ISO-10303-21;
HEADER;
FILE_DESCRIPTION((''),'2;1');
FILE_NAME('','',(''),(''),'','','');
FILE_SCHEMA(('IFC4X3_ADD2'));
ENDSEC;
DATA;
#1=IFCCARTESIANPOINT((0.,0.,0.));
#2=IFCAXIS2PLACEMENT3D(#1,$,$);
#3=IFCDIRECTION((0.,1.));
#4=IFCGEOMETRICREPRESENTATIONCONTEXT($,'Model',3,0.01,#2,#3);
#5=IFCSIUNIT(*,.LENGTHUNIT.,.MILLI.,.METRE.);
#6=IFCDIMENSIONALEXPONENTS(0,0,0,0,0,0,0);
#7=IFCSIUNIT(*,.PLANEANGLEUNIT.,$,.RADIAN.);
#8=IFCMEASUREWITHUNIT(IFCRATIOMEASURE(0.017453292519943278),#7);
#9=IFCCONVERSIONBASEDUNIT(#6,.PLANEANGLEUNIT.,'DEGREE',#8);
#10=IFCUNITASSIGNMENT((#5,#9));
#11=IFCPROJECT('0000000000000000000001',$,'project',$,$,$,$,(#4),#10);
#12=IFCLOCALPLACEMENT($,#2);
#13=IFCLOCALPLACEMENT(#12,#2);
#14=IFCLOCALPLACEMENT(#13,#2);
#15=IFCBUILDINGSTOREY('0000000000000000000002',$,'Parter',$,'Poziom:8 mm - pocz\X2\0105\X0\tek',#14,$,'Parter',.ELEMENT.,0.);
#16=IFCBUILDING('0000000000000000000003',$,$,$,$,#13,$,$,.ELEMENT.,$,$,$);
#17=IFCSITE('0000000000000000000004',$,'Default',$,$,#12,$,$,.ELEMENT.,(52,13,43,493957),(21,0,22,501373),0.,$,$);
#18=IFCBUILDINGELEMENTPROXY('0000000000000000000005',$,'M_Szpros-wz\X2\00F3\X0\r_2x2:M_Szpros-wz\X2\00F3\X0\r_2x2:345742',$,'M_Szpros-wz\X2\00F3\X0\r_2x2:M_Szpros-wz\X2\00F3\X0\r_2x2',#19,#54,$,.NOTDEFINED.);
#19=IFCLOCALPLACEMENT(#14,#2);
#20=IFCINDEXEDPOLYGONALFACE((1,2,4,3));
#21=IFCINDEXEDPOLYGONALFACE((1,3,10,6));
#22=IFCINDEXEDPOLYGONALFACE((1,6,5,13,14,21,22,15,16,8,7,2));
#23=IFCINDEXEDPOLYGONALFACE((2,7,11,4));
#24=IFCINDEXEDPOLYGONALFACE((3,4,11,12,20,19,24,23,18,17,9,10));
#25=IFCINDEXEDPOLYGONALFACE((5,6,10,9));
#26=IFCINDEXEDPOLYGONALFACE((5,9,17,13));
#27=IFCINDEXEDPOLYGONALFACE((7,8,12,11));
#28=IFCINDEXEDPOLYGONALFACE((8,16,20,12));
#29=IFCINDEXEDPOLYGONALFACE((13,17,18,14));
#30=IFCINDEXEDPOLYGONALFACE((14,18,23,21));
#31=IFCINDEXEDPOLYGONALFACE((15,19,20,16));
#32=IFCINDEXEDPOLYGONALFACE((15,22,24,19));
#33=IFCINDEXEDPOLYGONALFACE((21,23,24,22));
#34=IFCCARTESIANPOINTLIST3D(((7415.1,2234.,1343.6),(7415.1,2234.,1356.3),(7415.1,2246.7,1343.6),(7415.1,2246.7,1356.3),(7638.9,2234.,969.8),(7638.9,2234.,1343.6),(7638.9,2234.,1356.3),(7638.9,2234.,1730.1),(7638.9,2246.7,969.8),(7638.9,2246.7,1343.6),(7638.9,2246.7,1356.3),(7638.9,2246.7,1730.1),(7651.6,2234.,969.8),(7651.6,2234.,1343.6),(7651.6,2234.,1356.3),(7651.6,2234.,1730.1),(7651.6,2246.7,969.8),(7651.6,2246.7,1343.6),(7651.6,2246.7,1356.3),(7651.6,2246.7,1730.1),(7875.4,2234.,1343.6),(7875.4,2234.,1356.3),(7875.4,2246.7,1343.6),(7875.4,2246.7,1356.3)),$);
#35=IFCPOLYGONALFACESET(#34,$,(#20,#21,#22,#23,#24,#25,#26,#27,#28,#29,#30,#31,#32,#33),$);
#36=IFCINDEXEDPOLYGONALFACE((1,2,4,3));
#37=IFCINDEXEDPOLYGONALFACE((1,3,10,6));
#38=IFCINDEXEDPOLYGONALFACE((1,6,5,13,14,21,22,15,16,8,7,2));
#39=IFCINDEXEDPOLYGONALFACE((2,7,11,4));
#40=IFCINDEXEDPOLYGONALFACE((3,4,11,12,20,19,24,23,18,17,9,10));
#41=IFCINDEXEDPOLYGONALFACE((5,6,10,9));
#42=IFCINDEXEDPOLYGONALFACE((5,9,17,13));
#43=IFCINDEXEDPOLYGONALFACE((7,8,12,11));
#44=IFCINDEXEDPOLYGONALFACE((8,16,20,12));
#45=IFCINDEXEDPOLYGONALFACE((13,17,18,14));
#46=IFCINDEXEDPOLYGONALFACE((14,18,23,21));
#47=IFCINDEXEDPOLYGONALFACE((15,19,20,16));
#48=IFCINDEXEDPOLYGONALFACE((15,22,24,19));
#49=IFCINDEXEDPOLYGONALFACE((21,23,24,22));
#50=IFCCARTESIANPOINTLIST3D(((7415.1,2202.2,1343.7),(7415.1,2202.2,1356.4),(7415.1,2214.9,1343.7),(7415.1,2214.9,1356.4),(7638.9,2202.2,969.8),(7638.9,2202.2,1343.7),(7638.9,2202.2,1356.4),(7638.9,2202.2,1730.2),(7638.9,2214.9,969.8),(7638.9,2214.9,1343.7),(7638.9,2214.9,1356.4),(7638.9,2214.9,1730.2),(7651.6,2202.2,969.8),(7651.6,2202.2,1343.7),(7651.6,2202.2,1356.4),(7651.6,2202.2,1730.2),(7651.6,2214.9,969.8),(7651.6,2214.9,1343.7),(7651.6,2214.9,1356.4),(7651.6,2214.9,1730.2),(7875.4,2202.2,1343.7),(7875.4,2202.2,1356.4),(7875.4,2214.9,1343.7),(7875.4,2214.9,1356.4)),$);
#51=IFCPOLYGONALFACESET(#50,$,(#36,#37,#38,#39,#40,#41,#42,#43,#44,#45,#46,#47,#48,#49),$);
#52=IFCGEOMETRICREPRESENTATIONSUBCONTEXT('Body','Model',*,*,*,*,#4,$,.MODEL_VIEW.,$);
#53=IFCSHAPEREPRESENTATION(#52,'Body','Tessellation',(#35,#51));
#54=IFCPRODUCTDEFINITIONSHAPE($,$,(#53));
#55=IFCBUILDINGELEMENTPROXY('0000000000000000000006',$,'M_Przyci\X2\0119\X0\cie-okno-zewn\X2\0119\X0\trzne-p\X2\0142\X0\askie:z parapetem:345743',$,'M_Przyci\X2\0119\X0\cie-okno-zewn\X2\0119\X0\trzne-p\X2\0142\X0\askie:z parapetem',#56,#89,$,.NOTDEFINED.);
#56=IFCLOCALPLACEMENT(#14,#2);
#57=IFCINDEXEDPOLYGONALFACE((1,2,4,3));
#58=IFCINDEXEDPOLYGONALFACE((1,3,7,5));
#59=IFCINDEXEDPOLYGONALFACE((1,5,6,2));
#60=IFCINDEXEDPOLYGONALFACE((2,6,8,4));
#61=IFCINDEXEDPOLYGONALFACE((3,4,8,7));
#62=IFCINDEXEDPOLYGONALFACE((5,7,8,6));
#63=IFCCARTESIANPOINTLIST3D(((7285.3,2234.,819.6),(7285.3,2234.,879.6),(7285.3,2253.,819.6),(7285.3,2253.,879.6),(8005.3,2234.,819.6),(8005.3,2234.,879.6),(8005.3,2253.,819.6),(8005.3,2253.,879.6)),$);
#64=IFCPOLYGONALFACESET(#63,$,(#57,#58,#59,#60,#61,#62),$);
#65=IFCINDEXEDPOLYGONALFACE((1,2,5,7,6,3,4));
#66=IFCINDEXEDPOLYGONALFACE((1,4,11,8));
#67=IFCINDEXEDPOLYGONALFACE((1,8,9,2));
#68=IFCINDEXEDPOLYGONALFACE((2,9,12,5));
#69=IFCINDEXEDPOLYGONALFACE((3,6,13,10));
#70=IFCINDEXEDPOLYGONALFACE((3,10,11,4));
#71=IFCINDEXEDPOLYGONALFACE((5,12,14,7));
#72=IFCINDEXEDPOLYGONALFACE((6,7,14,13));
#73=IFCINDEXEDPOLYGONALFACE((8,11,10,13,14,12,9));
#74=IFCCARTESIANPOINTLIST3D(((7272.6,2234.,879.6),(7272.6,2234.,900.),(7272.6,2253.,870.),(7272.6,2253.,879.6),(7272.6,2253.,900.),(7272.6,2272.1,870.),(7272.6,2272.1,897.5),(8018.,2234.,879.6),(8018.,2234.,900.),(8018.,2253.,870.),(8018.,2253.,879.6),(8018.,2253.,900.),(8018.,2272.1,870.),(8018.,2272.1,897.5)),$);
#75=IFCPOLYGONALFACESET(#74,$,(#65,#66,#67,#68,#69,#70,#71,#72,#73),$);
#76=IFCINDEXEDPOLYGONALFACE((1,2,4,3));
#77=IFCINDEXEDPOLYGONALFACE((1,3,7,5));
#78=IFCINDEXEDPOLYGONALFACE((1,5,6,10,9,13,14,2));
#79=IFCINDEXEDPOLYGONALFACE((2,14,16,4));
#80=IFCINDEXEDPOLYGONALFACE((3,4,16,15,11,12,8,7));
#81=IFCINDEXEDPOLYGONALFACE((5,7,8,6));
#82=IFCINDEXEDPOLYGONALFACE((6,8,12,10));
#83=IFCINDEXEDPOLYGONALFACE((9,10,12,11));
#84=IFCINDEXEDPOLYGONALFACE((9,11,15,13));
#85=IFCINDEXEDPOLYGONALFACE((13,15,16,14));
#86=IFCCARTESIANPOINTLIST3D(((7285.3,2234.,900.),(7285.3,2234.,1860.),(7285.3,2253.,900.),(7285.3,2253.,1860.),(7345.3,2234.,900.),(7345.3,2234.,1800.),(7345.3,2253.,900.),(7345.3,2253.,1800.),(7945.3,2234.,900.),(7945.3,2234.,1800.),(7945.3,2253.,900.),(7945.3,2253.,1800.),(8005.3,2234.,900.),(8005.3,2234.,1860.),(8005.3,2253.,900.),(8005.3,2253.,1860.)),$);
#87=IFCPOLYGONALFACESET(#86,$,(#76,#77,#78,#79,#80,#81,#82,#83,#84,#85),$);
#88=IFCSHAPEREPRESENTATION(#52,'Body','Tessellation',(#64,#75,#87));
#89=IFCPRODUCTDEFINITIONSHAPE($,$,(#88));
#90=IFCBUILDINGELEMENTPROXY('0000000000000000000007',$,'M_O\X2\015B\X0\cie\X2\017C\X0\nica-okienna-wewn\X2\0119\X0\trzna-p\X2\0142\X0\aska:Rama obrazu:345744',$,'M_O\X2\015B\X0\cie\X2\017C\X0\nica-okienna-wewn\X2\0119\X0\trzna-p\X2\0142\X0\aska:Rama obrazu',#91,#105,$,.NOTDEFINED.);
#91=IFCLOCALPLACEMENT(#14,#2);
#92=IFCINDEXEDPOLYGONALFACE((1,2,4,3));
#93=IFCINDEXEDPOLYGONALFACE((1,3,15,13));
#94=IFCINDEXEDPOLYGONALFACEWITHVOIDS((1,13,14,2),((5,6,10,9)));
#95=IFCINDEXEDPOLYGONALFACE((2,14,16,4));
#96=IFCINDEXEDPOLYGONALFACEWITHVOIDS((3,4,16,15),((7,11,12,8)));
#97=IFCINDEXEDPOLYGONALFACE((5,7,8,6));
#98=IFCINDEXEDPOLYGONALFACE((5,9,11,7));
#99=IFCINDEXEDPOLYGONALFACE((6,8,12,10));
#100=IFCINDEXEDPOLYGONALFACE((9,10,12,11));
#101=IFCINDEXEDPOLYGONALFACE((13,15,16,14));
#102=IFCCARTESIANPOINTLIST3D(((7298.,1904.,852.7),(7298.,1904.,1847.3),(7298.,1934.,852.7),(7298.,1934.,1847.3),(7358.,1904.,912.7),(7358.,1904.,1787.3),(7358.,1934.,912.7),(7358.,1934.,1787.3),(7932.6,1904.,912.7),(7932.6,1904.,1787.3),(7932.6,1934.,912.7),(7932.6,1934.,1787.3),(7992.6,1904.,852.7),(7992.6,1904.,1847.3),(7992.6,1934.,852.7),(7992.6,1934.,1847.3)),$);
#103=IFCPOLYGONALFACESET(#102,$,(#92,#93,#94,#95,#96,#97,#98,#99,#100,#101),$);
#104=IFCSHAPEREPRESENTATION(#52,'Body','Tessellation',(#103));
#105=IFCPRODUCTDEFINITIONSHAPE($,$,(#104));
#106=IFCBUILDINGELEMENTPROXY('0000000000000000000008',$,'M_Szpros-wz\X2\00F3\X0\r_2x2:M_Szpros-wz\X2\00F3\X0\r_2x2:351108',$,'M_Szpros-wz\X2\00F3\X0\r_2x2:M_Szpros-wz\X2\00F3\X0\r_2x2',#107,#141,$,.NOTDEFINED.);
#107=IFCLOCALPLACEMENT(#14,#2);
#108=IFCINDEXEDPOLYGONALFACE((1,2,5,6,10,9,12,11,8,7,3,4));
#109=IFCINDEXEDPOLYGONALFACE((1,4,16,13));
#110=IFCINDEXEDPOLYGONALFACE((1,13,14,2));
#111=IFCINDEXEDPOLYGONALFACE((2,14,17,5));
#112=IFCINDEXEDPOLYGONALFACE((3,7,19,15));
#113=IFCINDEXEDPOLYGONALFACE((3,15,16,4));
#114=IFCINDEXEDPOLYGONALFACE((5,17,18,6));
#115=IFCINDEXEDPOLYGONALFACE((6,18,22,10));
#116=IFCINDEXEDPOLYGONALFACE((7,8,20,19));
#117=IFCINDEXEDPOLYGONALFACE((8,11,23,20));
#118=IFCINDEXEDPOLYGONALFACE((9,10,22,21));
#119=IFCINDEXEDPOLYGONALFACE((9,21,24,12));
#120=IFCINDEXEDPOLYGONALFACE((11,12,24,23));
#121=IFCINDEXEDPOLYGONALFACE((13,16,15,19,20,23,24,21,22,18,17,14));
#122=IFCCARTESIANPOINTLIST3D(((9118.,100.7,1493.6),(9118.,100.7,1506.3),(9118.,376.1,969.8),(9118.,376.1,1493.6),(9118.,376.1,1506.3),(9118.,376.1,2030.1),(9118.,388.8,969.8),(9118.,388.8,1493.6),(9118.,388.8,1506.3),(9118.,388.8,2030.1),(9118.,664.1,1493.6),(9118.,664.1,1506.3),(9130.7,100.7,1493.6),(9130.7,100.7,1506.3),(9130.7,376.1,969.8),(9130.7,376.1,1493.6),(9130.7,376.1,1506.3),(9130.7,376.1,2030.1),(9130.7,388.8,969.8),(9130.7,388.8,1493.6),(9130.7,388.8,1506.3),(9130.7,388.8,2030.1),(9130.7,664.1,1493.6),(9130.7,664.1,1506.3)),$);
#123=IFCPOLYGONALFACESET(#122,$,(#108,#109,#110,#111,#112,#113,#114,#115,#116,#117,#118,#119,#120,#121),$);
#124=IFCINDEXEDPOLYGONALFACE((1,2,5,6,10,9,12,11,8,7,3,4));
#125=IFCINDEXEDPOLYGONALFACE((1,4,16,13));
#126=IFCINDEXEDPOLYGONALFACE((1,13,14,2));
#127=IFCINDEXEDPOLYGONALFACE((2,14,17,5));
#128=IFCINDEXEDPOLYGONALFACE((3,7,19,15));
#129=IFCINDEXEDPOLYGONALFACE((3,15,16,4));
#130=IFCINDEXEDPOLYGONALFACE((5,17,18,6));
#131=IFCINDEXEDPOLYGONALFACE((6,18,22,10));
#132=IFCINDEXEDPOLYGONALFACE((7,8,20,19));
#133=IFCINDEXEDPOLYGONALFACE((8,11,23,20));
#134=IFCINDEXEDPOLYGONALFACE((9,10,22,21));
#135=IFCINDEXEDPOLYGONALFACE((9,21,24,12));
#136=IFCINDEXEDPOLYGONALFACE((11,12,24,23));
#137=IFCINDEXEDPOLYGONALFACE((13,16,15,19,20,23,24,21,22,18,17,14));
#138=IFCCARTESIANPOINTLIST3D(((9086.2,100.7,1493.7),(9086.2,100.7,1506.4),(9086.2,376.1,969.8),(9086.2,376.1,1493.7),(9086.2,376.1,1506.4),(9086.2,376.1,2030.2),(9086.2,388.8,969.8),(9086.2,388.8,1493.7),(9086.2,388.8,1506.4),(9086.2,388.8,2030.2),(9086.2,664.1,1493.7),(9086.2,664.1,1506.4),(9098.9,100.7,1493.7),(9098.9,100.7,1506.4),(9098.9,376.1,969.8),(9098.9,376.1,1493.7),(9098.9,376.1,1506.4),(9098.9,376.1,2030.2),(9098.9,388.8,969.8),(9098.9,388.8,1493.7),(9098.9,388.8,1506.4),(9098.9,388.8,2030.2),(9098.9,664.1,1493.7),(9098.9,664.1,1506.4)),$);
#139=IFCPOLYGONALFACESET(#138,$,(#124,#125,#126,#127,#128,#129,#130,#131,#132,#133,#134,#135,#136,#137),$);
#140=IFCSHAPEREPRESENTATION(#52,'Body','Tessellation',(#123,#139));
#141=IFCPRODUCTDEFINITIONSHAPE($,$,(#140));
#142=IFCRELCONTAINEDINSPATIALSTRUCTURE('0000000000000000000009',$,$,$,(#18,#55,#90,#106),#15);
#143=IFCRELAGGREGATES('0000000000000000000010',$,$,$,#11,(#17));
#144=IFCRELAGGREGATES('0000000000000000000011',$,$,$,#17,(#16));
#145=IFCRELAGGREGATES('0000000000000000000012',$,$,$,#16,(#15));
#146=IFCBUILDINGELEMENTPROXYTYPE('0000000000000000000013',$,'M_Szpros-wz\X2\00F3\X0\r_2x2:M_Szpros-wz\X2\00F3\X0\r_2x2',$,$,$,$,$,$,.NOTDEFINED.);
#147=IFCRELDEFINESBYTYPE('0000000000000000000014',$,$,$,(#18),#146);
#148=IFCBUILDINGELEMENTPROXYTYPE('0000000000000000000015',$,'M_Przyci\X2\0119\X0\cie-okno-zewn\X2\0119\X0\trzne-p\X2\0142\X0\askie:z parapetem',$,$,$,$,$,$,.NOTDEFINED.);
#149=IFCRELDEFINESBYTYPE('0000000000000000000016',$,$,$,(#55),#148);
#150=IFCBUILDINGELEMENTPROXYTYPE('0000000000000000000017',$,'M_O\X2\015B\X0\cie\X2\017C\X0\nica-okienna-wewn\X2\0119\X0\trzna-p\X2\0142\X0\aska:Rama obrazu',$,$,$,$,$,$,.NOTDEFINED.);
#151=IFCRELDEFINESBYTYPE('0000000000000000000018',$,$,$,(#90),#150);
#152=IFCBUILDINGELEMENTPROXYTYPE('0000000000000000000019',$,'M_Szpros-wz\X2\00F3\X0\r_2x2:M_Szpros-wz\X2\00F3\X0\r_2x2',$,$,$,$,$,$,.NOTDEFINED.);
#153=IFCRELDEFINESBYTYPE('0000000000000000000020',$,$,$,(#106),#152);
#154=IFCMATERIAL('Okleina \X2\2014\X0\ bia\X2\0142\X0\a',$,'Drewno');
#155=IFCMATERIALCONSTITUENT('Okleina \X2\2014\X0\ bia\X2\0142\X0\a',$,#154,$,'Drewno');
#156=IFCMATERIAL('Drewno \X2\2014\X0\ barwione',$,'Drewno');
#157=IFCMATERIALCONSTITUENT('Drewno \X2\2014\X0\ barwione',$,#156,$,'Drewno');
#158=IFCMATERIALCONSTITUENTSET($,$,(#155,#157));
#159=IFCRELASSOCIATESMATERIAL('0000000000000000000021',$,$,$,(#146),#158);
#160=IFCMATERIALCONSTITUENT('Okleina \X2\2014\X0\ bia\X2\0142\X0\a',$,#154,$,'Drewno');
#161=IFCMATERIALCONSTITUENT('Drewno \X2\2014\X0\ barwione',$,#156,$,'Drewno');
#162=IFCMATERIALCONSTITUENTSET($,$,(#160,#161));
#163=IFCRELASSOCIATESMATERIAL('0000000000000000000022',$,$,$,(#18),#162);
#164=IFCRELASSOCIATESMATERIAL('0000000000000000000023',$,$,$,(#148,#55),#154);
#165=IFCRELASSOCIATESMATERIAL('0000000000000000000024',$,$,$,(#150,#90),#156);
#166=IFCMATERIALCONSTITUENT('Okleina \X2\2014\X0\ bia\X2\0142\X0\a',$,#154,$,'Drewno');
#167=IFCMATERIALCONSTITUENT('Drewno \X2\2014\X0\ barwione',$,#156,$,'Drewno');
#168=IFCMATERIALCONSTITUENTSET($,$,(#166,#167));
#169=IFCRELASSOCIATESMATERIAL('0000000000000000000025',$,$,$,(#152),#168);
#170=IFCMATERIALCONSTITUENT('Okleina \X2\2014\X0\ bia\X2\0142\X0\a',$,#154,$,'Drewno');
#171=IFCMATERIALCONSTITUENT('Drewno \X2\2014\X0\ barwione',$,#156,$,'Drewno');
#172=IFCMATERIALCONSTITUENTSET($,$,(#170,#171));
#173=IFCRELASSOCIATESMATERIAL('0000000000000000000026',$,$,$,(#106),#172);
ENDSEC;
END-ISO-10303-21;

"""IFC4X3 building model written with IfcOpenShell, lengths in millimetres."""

from ifc_helpers import new_model, entity, si_unit, converted_unit, direction, frame, frame_2d, origin, place, context, subcontext, project, spatial, polyline, rectangle, outline, extrude, source, transform, mapped, material, constituent, constituent_set, type_object, type_shapes, element, save


model = new_model("IFC4X3")

# Units and contexts
model_context = context("Model", 3, precision=0.01, world=origin(), true_north=direction((0.0, 1.0)))
body_context = subcontext(model_context, "Body", "Model", "MODEL_VIEW")
ifc_project = project(units=[si_unit("LENGTHUNIT", "METRE", prefix="MILLI"), converted_unit("PLANEANGLEUNIT", "DEGREE", entity("IfcRatioMeasure", 0.017453292519943278), si_unit("PLANEANGLEUNIT", "RADIAN"), dimensions=[0, 0, 0, 0, 0, 0, 0])], contexts=[model_context])

# Site, building, storey
site_placement = place(None, origin())
site = spatial("IfcSite", under=ifc_project, at=site_placement, Name="Default", CompositionType="ELEMENT", RefLatitude=(52, 13, 43, 493957), RefLongitude=(21, 0, 22, 501373), RefElevation=0.0)
building_placement = place(site_placement, origin())
building = spatial("IfcBuilding", under=site, at=building_placement, CompositionType="ELEMENT")
storey_placement = place(building_placement, origin())
storey = spatial("IfcBuildingStorey", under=building, at=storey_placement, Name="Parter", ObjectType="Poziom:8 mm - początek", LongName="Parter", CompositionType="ELEMENT", Elevation=0.0)

# Building element proxies
ifc_material_1 = material(Name="Okleina — biała", Category="Drewno")
ifc_constituent_1 = constituent(ifc_material_1, Name="Okleina — biała", Category="Drewno")
ifc_material_2 = material(Name="Drewno — barwione", Category="Drewno")
ifc_constituent_2 = constituent(ifc_material_2, Name="Drewno — barwione", Category="Drewno")
ifc_constituent_set_1 = constituent_set(constituents=[ifc_constituent_1, ifc_constituent_2])
ifc_constituent_3 = constituent(ifc_material_1, Name="Okleina — biała", Category="Drewno")
ifc_constituent_4 = constituent(ifc_material_2, Name="Drewno — barwione", Category="Drewno")
ifc_constituent_set_2 = constituent_set(constituents=[ifc_constituent_3, ifc_constituent_4])
building_element_proxy_type_1 = type_object("IfcBuildingElementProxyType", Name="M_Szpros-wzór_2x2:M_Szpros-wzór_2x2", PredefinedType="NOTDEFINED", material=ifc_constituent_set_2)
shared_shape_1 = source(origin(), body_context, "Body", "SweptSolid", [
    extrude(outline(polyline([(6.4, -6.4), (380.1, -6.4), (380.1, 6.3), (6.4, 6.3), (6.4, 230.2), (-6.3, 230.2), (-6.3, 6.3), (-380.2, 6.3), (-380.2, -6.4), (-6.3, -6.4), (-6.3, -230.1), (6.4, -230.1), (6.4, -6.4)])), frame((0.0, 9.5, 380.1), z_axis=(0.0, 1.0, 0.0), x_axis=(0.0, 0.0, 1.0)), (0.0, 0.0, 1.0), 12.7),
    extrude(outline(polyline([(6.4, -6.4), (380.2, -6.4), (380.2, 6.3), (6.4, 6.3), (6.4, 230.2), (-6.3, 230.2), (-6.3, 6.3), (-380.2, 6.3), (-380.2, -6.4), (-6.3, -6.4), (-6.3, -230.1), (6.4, -230.1), (6.4, -6.4)])), frame((0.0, -22.2, 380.2), z_axis=(0.0, 1.0, 0.0), x_axis=(0.0, 0.0, 1.0)), (0.0, 0.0, 1.0), 12.7),
])
type_shapes(building_element_proxy_type_1, [shared_shape_1])
proxy_1_placement = place(storey_placement, frame((7645.3, 2224.5, 969.8)))
element("IfcBuildingElementProxy", 1, at=proxy_1_placement, inside=storey, type_object=building_element_proxy_type_1, material=ifc_constituent_set_1, Name="M_Szpros-wzór_2x2:M_Szpros-wzór_2x2:345742", ObjectType="M_Szpros-wzór_2x2:M_Szpros-wzór_2x2", PredefinedType="NOTDEFINED", context=body_context, shape_type="MappedRepresentation", body=[
    mapped(shared_shape_1, transform((0.0, 0.0, 0.0), scale=1.0)),
])
building_element_proxy_type_2 = type_object("IfcBuildingElementProxyType", Name="M_Przycięcie-okno-zewnętrzne-płaskie:z parapetem", PredefinedType="NOTDEFINED", material=ifc_material_1)
shared_shape_2 = source(origin(), body_context, "Body", "SweptSolid", [
    extrude(rectangle(XDim=720.0, YDim=60.0, at=frame_2d((0.0, 0.0), x_axis=(1.0, 0.0))), frame((0.0, -950.4, 0.0), z_axis=(0.0, 0.0, 1.0), x_axis=(-1.0, 0.0, 0.0)), (0.0, 0.0, 1.0), 19.0),
    extrude(outline(polyline([(-19.0, -15.2), (0.0, -15.2), (0.0, -5.7), (19.0, -5.7), (19.0, 14.8), (0.0, 14.8), (-19.0, 12.3), (-19.0, -15.2)])), frame((-372.7, -914.8, 19.0), z_axis=(1.0, 0.0, 0.0), x_axis=(0.0, 0.0, -1.0)), (0.0, 0.0, 1.0), 745.4),
    extrude(outline(polyline([(-495.0, -360.0), (465.0, -360.0), (465.0, -300.0), (-435.0, -300.0), (-435.0, 300.0), (465.0, 300.0), (465.0, 360.0), (-495.0, 360.0), (-495.0, -360.0)])), frame((0.0, -435.0, 0.0), z_axis=(0.0, 0.0, 1.0), x_axis=(0.0, -1.0, 0.0)), (0.0, 0.0, 1.0), 19.0),
])
type_shapes(building_element_proxy_type_2, [shared_shape_2])
proxy_2_placement = place(storey_placement, frame((7645.3, 2234.0, 1800.0), z_axis=(0.0, 1.0, 0.0), x_axis=(-1.0, 0.0, 0.0)))
element("IfcBuildingElementProxy", 2, at=proxy_2_placement, inside=storey, type_object=building_element_proxy_type_2, material=ifc_material_1, Name="M_Przycięcie-okno-zewnętrzne-płaskie:z parapetem:345743", ObjectType="M_Przycięcie-okno-zewnętrzne-płaskie:z parapetem", PredefinedType="NOTDEFINED", context=body_context, shape_type="MappedRepresentation", body=[
    mapped(shared_shape_2, transform((0.0, 0.0, 0.0), scale=1.0)),
])
building_element_proxy_type_3 = type_object("IfcBuildingElementProxyType", Name="M_Ościeżnica-okienna-wewnętrzna-płaska:Rama obrazu", PredefinedType="NOTDEFINED", material=ifc_material_2)
shared_shape_3 = source(origin(), body_context, "Body", "SweptSolid", [
    extrude(outline(polyline([(-347.3, -497.3), (347.3, -497.3), (347.3, 497.3), (-347.3, 497.3), (-347.3, -497.3)]), holes=[polyline([(-287.3, -437.3), (-287.3, 437.3), (287.3, 437.3), (287.3, -437.3), (-287.3, -437.3)])]), frame((0.0, -450.0, 0.0), z_axis=(0.0, 0.0, 1.0), x_axis=(-1.0, 0.0, 0.0)), (0.0, 0.0, 1.0), 30.0),
])
type_shapes(building_element_proxy_type_3, [shared_shape_3])
proxy_3_placement = place(storey_placement, frame((7645.3, 1934.0, 1800.0), z_axis=(0.0, -1.0, 0.0), x_axis=(1.0, 0.0, 0.0)))
element("IfcBuildingElementProxy", 3, at=proxy_3_placement, inside=storey, type_object=building_element_proxy_type_3, material=ifc_material_2, Name="M_Ościeżnica-okienna-wewnętrzna-płaska:Rama obrazu:345744", ObjectType="M_Ościeżnica-okienna-wewnętrzna-płaska:Rama obrazu", PredefinedType="NOTDEFINED", context=body_context, shape_type="MappedRepresentation", body=[
    mapped(shared_shape_3, transform((0.0, 0.0, 0.0), scale=1.0)),
])
ifc_constituent_5 = constituent(ifc_material_1, Name="Okleina — biała", Category="Drewno")
ifc_constituent_6 = constituent(ifc_material_2, Name="Drewno — barwione", Category="Drewno")
ifc_constituent_set_3 = constituent_set(constituents=[ifc_constituent_5, ifc_constituent_6])
ifc_constituent_7 = constituent(ifc_material_1, Name="Okleina — biała", Category="Drewno")
ifc_constituent_8 = constituent(ifc_material_2, Name="Drewno — barwione", Category="Drewno")
ifc_constituent_set_4 = constituent_set(constituents=[ifc_constituent_7, ifc_constituent_8])
building_element_proxy_type_4 = type_object("IfcBuildingElementProxyType", Name="M_Szpros-wzór_2x2:M_Szpros-wzór_2x2", PredefinedType="NOTDEFINED", material=ifc_constituent_set_4)
shared_shape_4 = source(origin(), body_context, "Body", "SweptSolid", [
    extrude(outline(polyline([(6.4, -6.4), (530.1, -6.4), (530.1, 6.3), (6.4, 6.3), (6.4, 281.7), (-6.3, 281.7), (-6.3, 6.3), (-530.2, 6.3), (-530.2, -6.4), (-6.3, -6.4), (-6.3, -281.7), (6.4, -281.7), (6.4, -6.4)])), frame((0.0, 9.5, 530.1), z_axis=(0.0, 1.0, 0.0), x_axis=(0.0, 0.0, 1.0)), (0.0, 0.0, 1.0), 12.7),
    extrude(outline(polyline([(6.4, -6.4), (530.2, -6.4), (530.2, 6.3), (6.4, 6.3), (6.4, 281.7), (-6.3, 281.7), (-6.3, 6.3), (-530.2, 6.3), (-530.2, -6.4), (-6.3, -6.4), (-6.3, -281.7), (6.4, -281.7), (6.4, -6.4)])), frame((0.0, -22.2, 530.2), z_axis=(0.0, 1.0, 0.0), x_axis=(0.0, 0.0, 1.0)), (0.0, 0.0, 1.0), 12.7),
])
type_shapes(building_element_proxy_type_4, [shared_shape_4])
proxy_4_placement = place(storey_placement, frame((9108.4, 382.4, 969.8), z_axis=(0.0, 0.0, 1.0), x_axis=(0.0, -1.0, 0.0)))
element("IfcBuildingElementProxy", 4, at=proxy_4_placement, inside=storey, type_object=building_element_proxy_type_4, material=ifc_constituent_set_3, Name="M_Szpros-wzór_2x2:M_Szpros-wzór_2x2:351108", ObjectType="M_Szpros-wzór_2x2:M_Szpros-wzór_2x2", PredefinedType="NOTDEFINED", context=body_context, shape_type="MappedRepresentation", body=[
    mapped(shared_shape_4, transform((0.0, 0.0, 0.0), scale=1.0)),
])

save(model, "model.ifc")
